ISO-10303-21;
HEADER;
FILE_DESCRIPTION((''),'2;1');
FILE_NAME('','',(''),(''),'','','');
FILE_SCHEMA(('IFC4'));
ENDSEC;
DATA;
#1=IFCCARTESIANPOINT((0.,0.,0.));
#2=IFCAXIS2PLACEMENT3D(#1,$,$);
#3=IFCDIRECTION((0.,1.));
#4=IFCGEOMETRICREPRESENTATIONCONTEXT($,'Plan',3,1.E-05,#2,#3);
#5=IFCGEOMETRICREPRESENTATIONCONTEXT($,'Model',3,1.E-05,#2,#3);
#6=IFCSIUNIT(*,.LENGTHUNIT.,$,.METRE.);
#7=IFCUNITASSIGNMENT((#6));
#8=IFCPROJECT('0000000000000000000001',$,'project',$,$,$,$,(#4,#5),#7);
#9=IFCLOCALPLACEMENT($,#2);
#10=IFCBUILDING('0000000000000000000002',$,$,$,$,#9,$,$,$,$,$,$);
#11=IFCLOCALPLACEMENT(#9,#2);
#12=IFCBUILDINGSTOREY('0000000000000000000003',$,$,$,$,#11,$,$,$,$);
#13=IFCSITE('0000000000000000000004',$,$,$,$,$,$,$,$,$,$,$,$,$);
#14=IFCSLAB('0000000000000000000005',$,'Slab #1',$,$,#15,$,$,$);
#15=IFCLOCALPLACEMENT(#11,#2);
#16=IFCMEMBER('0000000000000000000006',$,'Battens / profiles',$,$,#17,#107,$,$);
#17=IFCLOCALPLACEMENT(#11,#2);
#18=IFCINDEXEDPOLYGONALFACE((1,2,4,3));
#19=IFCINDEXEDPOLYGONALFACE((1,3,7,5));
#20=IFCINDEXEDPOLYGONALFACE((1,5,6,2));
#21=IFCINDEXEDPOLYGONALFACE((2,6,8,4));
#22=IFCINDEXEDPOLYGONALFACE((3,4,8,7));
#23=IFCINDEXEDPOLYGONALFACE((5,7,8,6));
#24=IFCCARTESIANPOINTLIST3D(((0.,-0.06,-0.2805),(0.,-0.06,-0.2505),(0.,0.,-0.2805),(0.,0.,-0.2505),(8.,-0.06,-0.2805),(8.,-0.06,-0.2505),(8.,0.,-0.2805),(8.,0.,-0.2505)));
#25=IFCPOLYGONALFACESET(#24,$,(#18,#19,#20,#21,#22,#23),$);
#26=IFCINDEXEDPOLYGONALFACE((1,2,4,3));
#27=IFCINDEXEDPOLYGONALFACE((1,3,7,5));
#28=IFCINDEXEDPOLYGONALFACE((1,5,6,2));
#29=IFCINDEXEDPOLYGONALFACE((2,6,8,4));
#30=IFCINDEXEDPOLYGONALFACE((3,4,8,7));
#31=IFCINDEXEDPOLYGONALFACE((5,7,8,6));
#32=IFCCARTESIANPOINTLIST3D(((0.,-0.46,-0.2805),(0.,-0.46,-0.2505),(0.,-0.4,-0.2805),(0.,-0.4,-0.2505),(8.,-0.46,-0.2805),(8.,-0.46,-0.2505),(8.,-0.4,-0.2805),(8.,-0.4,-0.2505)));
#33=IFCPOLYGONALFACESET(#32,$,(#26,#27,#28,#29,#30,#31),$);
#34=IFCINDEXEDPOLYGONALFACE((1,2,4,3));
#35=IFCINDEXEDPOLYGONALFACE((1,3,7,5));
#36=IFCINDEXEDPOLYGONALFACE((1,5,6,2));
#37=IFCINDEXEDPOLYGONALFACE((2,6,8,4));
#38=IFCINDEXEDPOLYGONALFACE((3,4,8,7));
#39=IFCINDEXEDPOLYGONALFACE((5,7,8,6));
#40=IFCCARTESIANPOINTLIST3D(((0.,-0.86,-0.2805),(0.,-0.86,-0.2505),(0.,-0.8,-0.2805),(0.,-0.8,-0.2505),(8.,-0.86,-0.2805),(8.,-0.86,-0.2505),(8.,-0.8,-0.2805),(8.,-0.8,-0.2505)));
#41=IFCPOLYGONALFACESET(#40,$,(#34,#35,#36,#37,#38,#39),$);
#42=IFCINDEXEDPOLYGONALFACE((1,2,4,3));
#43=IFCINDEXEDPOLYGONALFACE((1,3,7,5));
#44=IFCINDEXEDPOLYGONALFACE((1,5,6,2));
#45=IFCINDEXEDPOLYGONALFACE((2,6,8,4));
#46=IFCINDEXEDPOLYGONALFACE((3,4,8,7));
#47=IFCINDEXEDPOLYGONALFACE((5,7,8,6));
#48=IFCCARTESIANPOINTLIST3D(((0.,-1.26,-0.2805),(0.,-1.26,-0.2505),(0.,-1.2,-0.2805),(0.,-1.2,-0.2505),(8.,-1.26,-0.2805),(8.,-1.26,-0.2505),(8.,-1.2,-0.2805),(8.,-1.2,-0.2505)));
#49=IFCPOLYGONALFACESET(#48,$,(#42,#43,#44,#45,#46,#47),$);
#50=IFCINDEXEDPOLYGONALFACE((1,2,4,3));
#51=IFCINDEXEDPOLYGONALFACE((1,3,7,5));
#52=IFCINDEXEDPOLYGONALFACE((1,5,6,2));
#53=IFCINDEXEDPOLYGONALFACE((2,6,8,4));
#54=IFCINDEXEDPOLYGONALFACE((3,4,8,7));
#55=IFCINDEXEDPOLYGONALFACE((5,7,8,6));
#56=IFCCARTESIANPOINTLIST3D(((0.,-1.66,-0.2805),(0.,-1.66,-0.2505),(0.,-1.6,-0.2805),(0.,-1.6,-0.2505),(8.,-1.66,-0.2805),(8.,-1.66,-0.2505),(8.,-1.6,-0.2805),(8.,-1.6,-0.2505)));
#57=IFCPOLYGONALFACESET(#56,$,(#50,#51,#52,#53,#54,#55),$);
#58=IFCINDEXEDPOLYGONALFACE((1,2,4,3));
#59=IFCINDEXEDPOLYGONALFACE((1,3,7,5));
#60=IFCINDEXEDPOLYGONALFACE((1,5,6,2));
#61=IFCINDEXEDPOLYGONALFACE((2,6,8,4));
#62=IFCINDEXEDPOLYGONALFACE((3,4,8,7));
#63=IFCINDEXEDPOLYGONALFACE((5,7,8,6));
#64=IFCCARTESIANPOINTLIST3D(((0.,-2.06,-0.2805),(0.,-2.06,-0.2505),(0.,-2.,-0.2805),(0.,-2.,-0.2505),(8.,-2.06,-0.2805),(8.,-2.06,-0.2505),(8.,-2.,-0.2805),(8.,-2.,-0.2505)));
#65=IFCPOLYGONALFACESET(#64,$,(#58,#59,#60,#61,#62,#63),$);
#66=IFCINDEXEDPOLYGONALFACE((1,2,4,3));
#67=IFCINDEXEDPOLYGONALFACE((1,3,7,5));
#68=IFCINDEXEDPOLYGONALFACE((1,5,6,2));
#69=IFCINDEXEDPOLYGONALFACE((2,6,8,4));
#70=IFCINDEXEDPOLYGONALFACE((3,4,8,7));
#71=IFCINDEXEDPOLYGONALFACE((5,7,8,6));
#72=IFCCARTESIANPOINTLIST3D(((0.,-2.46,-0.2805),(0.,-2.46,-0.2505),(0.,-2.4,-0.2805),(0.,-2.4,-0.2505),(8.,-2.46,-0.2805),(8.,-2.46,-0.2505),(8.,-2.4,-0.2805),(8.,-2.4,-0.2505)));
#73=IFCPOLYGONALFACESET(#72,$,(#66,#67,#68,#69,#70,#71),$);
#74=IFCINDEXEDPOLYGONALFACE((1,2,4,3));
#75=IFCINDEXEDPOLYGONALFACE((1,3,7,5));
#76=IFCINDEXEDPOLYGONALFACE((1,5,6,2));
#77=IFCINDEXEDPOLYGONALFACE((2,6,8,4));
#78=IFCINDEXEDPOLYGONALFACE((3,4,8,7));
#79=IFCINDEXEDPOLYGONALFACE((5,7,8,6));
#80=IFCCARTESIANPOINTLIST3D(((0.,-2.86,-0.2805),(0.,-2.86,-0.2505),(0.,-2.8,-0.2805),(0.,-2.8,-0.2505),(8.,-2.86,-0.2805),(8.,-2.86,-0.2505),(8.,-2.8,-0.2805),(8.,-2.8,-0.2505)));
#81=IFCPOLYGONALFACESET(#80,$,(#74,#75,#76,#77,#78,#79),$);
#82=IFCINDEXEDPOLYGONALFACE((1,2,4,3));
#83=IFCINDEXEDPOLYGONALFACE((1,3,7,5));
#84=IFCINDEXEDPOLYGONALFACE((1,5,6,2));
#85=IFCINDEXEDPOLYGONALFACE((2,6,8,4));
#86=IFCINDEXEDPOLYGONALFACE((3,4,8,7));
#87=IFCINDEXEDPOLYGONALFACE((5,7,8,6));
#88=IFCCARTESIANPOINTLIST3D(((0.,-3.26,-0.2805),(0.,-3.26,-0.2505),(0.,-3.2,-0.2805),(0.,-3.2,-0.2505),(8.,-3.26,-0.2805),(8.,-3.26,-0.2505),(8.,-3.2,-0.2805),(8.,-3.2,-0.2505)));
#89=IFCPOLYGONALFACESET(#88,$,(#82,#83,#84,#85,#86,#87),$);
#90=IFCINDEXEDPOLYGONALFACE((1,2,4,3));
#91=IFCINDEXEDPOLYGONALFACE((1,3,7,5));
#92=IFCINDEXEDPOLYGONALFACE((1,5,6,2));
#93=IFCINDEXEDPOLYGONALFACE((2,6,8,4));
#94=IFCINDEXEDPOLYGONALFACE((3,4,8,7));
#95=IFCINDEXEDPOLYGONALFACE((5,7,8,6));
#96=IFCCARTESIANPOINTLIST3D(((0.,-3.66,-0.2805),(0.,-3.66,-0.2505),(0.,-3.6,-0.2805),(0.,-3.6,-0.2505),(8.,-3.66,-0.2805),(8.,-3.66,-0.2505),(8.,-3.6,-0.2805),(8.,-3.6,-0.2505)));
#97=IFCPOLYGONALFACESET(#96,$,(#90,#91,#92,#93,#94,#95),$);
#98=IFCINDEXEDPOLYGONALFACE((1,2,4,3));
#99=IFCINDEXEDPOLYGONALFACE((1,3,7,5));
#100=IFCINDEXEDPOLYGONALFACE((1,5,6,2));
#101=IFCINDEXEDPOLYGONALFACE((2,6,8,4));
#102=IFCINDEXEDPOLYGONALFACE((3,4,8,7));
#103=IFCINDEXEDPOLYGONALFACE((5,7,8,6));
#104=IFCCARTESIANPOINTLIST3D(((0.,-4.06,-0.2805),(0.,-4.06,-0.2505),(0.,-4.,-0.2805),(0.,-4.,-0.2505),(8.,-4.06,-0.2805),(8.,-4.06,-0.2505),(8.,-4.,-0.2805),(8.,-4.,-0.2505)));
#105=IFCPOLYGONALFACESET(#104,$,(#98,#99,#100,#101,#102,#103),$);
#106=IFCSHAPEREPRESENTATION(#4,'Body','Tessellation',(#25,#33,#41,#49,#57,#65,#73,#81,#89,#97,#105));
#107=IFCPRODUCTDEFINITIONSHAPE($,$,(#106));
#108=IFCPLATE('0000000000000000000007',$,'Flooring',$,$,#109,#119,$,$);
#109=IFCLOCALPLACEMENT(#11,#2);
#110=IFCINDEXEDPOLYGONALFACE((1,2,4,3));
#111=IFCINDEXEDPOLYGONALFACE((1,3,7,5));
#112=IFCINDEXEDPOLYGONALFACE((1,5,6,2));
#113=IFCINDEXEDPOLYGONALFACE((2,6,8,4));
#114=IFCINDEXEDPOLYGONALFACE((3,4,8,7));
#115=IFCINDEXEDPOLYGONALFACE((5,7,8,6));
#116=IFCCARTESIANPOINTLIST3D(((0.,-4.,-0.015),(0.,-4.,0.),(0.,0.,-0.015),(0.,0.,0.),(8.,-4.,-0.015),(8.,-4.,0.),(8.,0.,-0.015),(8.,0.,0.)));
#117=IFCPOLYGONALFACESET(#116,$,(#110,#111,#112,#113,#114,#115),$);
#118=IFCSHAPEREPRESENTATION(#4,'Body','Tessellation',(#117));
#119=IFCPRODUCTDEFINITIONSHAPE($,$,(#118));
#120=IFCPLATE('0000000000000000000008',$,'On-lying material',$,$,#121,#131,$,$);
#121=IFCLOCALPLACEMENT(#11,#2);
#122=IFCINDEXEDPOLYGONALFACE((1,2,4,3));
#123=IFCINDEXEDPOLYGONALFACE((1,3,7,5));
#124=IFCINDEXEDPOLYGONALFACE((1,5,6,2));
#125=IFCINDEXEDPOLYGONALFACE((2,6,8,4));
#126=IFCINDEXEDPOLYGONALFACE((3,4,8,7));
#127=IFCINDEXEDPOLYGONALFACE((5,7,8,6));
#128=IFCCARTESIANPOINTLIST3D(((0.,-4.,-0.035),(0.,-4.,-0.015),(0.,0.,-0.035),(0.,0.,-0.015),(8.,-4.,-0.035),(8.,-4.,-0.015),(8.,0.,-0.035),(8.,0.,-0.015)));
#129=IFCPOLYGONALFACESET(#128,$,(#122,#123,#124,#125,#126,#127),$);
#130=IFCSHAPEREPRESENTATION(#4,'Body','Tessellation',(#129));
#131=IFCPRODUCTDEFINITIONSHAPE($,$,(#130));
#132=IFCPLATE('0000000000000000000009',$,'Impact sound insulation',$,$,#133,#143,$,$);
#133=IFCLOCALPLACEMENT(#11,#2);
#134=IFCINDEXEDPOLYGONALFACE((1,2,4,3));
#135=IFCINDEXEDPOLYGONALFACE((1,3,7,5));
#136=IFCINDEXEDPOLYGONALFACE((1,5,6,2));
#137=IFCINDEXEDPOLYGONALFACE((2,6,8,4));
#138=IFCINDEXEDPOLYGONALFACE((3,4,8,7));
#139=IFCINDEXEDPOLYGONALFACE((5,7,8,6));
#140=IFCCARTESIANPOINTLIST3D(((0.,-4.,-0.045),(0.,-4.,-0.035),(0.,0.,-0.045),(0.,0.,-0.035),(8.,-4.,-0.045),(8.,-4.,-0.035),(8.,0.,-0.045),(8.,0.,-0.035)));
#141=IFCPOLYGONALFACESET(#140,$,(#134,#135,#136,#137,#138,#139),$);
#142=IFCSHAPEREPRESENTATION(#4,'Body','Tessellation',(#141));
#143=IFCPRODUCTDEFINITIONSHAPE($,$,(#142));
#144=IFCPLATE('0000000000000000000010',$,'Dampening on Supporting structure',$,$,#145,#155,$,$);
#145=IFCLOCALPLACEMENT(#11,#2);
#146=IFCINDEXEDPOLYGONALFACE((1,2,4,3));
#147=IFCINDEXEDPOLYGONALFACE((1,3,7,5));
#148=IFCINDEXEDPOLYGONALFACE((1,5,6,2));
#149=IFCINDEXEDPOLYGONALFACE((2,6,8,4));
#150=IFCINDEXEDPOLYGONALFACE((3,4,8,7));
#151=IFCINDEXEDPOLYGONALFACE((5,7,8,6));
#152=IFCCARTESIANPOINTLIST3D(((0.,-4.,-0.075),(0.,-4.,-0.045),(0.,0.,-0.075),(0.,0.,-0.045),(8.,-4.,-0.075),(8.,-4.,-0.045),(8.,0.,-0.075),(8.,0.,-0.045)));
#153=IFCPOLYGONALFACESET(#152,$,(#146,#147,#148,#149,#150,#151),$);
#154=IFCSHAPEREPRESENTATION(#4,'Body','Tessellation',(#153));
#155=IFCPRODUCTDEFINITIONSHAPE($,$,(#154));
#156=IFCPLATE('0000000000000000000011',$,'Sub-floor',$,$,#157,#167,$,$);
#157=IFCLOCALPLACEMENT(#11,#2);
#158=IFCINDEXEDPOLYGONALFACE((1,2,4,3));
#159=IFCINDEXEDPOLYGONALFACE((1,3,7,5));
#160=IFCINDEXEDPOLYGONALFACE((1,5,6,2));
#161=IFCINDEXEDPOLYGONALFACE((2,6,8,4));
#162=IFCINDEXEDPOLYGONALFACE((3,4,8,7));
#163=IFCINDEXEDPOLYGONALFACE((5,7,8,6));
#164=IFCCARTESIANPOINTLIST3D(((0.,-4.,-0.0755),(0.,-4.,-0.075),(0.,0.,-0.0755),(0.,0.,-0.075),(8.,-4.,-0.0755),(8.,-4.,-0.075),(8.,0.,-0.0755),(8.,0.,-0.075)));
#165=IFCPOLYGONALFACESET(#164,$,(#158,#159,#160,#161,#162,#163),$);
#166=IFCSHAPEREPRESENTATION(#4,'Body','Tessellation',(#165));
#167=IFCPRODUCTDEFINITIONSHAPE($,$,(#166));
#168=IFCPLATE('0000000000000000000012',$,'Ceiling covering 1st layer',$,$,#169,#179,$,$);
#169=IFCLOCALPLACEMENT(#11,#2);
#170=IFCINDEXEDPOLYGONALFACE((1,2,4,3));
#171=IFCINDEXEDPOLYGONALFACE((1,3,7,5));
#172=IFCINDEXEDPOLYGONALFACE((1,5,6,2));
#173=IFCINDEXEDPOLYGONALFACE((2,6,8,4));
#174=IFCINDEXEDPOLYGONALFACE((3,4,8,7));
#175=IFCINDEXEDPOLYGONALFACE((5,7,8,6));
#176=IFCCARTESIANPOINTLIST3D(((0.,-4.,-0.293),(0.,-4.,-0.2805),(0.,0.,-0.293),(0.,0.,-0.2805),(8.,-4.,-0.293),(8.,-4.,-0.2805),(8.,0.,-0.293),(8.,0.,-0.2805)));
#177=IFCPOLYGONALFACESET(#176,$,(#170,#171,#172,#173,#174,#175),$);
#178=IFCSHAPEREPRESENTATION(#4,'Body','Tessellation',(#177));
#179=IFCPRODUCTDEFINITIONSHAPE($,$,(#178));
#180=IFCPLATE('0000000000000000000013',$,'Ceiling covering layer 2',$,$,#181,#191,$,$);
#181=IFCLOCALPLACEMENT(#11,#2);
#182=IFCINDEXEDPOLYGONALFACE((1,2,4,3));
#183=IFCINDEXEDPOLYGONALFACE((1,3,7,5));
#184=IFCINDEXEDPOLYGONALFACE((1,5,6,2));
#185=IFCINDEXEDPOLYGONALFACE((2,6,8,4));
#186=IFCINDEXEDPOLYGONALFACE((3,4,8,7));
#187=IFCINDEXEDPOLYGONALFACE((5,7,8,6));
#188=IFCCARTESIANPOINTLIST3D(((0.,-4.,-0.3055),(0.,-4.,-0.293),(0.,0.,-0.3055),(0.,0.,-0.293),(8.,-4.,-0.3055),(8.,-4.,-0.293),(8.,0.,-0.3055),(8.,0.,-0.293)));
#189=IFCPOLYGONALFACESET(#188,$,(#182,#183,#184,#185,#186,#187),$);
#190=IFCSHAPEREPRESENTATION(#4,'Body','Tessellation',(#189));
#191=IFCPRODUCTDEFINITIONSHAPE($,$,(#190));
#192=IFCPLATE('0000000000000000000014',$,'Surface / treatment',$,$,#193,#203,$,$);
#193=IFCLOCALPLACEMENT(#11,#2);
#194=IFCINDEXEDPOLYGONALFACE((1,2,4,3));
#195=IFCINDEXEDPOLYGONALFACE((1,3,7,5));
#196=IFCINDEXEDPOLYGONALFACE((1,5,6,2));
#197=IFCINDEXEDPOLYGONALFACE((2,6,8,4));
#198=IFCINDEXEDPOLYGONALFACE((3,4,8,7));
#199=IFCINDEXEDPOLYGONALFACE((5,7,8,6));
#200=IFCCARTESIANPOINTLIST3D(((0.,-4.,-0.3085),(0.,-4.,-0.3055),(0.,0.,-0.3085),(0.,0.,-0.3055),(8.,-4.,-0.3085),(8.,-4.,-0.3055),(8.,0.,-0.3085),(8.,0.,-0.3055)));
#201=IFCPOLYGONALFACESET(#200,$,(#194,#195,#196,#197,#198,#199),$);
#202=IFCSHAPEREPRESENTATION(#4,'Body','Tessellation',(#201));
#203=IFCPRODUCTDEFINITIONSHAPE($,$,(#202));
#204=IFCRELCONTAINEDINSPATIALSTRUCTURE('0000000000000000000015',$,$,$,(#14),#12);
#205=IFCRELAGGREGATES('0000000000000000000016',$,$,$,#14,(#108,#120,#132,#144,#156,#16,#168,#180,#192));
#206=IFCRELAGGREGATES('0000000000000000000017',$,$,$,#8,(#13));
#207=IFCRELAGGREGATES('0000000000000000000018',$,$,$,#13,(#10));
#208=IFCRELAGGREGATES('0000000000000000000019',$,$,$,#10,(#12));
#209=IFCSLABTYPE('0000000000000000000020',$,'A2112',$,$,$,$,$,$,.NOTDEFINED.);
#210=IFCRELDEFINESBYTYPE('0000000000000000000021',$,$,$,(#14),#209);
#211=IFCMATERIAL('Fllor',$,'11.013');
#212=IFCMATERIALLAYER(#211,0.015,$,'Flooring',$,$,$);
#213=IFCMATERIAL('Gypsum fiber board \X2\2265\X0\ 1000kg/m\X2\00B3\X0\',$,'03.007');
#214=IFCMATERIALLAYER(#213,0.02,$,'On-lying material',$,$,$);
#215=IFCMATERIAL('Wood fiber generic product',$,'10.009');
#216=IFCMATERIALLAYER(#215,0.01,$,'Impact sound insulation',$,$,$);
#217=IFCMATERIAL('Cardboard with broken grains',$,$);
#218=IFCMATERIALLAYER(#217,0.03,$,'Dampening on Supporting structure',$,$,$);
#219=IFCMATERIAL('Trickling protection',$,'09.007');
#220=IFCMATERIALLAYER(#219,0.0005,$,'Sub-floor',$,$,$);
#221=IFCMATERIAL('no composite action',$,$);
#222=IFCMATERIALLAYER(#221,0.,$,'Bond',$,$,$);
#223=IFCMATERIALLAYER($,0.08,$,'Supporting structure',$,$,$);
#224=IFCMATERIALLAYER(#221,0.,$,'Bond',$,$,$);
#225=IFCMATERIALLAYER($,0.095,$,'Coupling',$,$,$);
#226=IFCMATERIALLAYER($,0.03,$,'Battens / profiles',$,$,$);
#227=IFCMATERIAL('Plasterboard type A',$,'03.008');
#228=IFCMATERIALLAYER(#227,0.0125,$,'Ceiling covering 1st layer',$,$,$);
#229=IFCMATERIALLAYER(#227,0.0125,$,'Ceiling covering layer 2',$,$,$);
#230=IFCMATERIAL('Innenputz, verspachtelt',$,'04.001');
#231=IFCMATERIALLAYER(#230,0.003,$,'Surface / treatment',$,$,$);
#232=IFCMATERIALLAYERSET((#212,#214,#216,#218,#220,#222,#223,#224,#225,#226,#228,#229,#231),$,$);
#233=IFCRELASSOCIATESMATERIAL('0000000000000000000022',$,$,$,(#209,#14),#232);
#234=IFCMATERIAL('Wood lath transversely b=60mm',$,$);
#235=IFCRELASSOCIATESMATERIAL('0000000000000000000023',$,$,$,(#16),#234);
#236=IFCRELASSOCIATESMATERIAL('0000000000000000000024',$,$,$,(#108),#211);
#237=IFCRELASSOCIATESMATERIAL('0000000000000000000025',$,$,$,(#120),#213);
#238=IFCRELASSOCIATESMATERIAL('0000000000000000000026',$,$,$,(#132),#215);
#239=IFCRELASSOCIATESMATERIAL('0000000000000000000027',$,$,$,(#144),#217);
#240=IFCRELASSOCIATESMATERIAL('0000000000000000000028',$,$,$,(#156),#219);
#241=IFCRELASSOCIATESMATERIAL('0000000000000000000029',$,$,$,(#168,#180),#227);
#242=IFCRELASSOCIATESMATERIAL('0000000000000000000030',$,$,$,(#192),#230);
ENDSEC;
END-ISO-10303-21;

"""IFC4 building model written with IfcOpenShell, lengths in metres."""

from ifc_helpers import new_model, si_unit, direction, frame, frame_2d, origin, origin_with_axes, place, context, project, spatial, rectangle, extrude, material, layer, layer_set, type_object, element, aggregate, save


model = new_model("IFC4")

# Units and contexts
plan_context = context("Plan", 3, precision=1e-05, world=origin(), true_north=direction((0.0, 1.0)))
model_context = context("Model", 3, precision=1e-05, world=origin(), true_north=direction((0.0, 1.0)))
ifc_project = project(units=[si_unit("LENGTHUNIT", "METRE")], contexts=[plan_context, model_context])

# Site, building, storey
site = spatial("IfcSite", under=ifc_project)
building_placement = place(None, origin())
building = spatial("IfcBuilding", under=site, at=building_placement)
storey_placement = place(building_placement, origin())
storey = spatial("IfcBuildingStorey", under=building, at=storey_placement)

# Slab, member, plates
ifc_material_1 = material(Name="Fllor", Category="11.013")
ifc_layer_1 = layer(ifc_material_1, 0.015, Name="Flooring")
ifc_material_2 = material(Name="Gypsum fiber board ≥ 1000kg/m³", Category="03.007")
ifc_layer_2 = layer(ifc_material_2, 0.02, Name="On-lying material")
ifc_material_3 = material(Name="Wood fiber generic product", Category="10.009")
ifc_layer_3 = layer(ifc_material_3, 0.01, Name="Impact sound insulation")
ifc_material_4 = material(Name="Cardboard with broken grains")
ifc_layer_4 = layer(ifc_material_4, 0.03, Name="Dampening on Supporting structure")
ifc_material_5 = material(Name="Trickling protection", Category="09.007")
ifc_layer_5 = layer(ifc_material_5, 0.0005, Name="Sub-floor")
ifc_material_6 = material(Name="no composite action")
ifc_layer_6 = layer(ifc_material_6, 0.0, Name="Bond")
ifc_layer_7 = layer(None, 0.08, Name="Supporting structure")
ifc_layer_8 = layer(ifc_material_6, 0.0, Name="Bond")
ifc_layer_9 = layer(None, 0.095, Name="Coupling")
ifc_layer_10 = layer(None, 0.03, Name="Battens / profiles")
ifc_material_7 = material(Name="Plasterboard type A", Category="03.008")
ifc_layer_11 = layer(ifc_material_7, 0.0125, Name="Ceiling covering 1st layer")
ifc_layer_12 = layer(ifc_material_7, 0.0125, Name="Ceiling covering layer 2")
ifc_material_8 = material(Name="Innenputz, verspachtelt", Category="04.001")
ifc_layer_13 = layer(ifc_material_8, 0.003, Name="Surface / treatment")
ifc_layer_set = layer_set([ifc_layer_1, ifc_layer_2, ifc_layer_3, ifc_layer_4, ifc_layer_5, ifc_layer_6, ifc_layer_7, ifc_layer_8, ifc_layer_9, ifc_layer_10, ifc_layer_11, ifc_layer_12, ifc_layer_13])
slab_type = type_object("IfcSlabType", Name="A2112", PredefinedType="NOTDEFINED", material=ifc_layer_set)
slab_placement = place(None, frame((0.0, 0.0, 0.0), z_axis=(0.0, 0.0, -1.0), x_axis=(1.0, 0.0, 0.0)))
slab = element("IfcSlab", 1, at=slab_placement, inside=storey, type_object=slab_type, material=ifc_layer_set, Name="Slab #1")
ifc_material_9 = material(Name="Wood lath transversely b=60mm")
member_1_placement = place(slab_placement, origin())
member_1 = element("IfcMember", 2, at=member_1_placement, material=ifc_material_9, Name="Battens / profiles", context=plan_context, shape_type="SweptSolid", body=[
    extrude(rectangle(XDim=0.06, YDim=0.03, at=frame_2d((0.03, 0.015), x_axis=(1.0, 0.0))), frame((0.0, 0.0, 0.2505), z_axis=(1.0, 0.0, 0.0), x_axis=(0.0, 1.0, 0.0)), (0.0, 0.0, 1.0), 8.0),
    extrude(rectangle(XDim=0.06, YDim=0.03, at=frame_2d((0.03, 0.015), x_axis=(1.0, 0.0))), frame((0.0, 0.4, 0.2505), z_axis=(1.0, 0.0, 0.0), x_axis=(0.0, 1.0, 0.0)), (0.0, 0.0, 1.0), 8.0),
    extrude(rectangle(XDim=0.06, YDim=0.03, at=frame_2d((0.03, 0.015), x_axis=(1.0, 0.0))), frame((0.0, 0.8, 0.2505), z_axis=(1.0, 0.0, 0.0), x_axis=(0.0, 1.0, 0.0)), (0.0, 0.0, 1.0), 8.0),
    extrude(rectangle(XDim=0.06, YDim=0.03, at=frame_2d((0.03, 0.015), x_axis=(1.0, 0.0))), frame((0.0, 1.2, 0.2505), z_axis=(1.0, 0.0, 0.0), x_axis=(0.0, 1.0, 0.0)), (0.0, 0.0, 1.0), 8.0),
    extrude(rectangle(XDim=0.06, YDim=0.03, at=frame_2d((0.03, 0.015), x_axis=(1.0, 0.0))), frame((0.0, 1.6, 0.2505), z_axis=(1.0, 0.0, 0.0), x_axis=(0.0, 1.0, 0.0)), (0.0, 0.0, 1.0), 8.0),
    extrude(rectangle(XDim=0.06, YDim=0.03, at=frame_2d((0.03, 0.015), x_axis=(1.0, 0.0))), frame((0.0, 2.0, 0.2505), z_axis=(1.0, 0.0, 0.0), x_axis=(0.0, 1.0, 0.0)), (0.0, 0.0, 1.0), 8.0),
    extrude(rectangle(XDim=0.06, YDim=0.03, at=frame_2d((0.03, 0.015), x_axis=(1.0, 0.0))), frame((0.0, 2.4, 0.2505), z_axis=(1.0, 0.0, 0.0), x_axis=(0.0, 1.0, 0.0)), (0.0, 0.0, 1.0), 8.0),
    extrude(rectangle(XDim=0.06, YDim=0.03, at=frame_2d((0.03, 0.015), x_axis=(1.0, 0.0))), frame((0.0, 2.8, 0.2505), z_axis=(1.0, 0.0, 0.0), x_axis=(0.0, 1.0, 0.0)), (0.0, 0.0, 1.0), 8.0),
    extrude(rectangle(XDim=0.06, YDim=0.03, at=frame_2d((0.03, 0.015), x_axis=(1.0, 0.0))), frame((0.0, 3.2, 0.2505), z_axis=(1.0, 0.0, 0.0), x_axis=(0.0, 1.0, 0.0)), (0.0, 0.0, 1.0), 8.0),
    extrude(rectangle(XDim=0.06, YDim=0.03, at=frame_2d((0.03, 0.015), x_axis=(1.0, 0.0))), frame((0.0, 3.6, 0.2505), z_axis=(1.0, 0.0, 0.0), x_axis=(0.0, 1.0, 0.0)), (0.0, 0.0, 1.0), 8.0),
    extrude(rectangle(XDim=0.06, YDim=0.03, at=frame_2d((0.03, 0.015), x_axis=(1.0, 0.0))), frame((0.0, 4.0, 0.2505), z_axis=(1.0, 0.0, 0.0), x_axis=(0.0, 1.0, 0.0)), (0.0, 0.0, 1.0), 8.0),
])
plate_1_placement = place(slab_placement, origin())
plate_1 = element("IfcPlate", 3, at=plate_1_placement, material=ifc_material_1, Name="Flooring", context=plan_context, shape_type="SweptSolid", body=[
    extrude(rectangle(XDim=8.0, YDim=4.0, at=frame_2d((4.0, 2.0), x_axis=(1.0, 0.0))), origin_with_axes(), (0.0, 0.0, 1.0), 0.015),
])
plate_2_placement = place(slab_placement, origin())
plate_2 = element("IfcPlate", 4, at=plate_2_placement, material=ifc_material_2, Name="On-lying material", context=plan_context, shape_type="SweptSolid", body=[
    extrude(rectangle(XDim=8.0, YDim=4.0, at=frame_2d((4.0, 2.0), x_axis=(1.0, 0.0))), frame((0.0, 0.0, 0.015), z_axis=(0.0, 0.0, 1.0), x_axis=(1.0, 0.0, 0.0)), (0.0, 0.0, 1.0), 0.02),
])
plate_3_placement = place(slab_placement, origin())
plate_3 = element("IfcPlate", 5, at=plate_3_placement, material=ifc_material_3, Name="Impact sound insulation", context=plan_context, shape_type="SweptSolid", body=[
    extrude(rectangle(XDim=8.0, YDim=4.0, at=frame_2d((4.0, 2.0), x_axis=(1.0, 0.0))), frame((0.0, 0.0, 0.035), z_axis=(0.0, 0.0, 1.0), x_axis=(1.0, 0.0, 0.0)), (0.0, 0.0, 1.0), 0.01),
])
plate_4_placement = place(slab_placement, origin())
plate_4 = element("IfcPlate", 6, at=plate_4_placement, material=ifc_material_4, Name="Dampening on Supporting structure", context=plan_context, shape_type="SweptSolid", body=[
    extrude(rectangle(XDim=8.0, YDim=4.0, at=frame_2d((4.0, 2.0), x_axis=(1.0, 0.0))), frame((0.0, 0.0, 0.045), z_axis=(0.0, 0.0, 1.0), x_axis=(1.0, 0.0, 0.0)), (0.0, 0.0, 1.0), 0.03),
])
plate_5_placement = place(slab_placement, origin())
plate_5 = element("IfcPlate", 7, at=plate_5_placement, material=ifc_material_5, Name="Sub-floor", context=plan_context, shape_type="SweptSolid", body=[
    extrude(rectangle(XDim=8.0, YDim=4.0, at=frame_2d((4.0, 2.0), x_axis=(1.0, 0.0))), frame((0.0, 0.0, 0.075), z_axis=(0.0, 0.0, 1.0), x_axis=(1.0, 0.0, 0.0)), (0.0, 0.0, 1.0), 0.0005),
])
plate_6_placement = place(slab_placement, origin())
plate_6 = element("IfcPlate", 8, at=plate_6_placement, material=ifc_material_7, Name="Ceiling covering 1st layer", context=plan_context, shape_type="SweptSolid", body=[
    extrude(rectangle(XDim=8.0, YDim=4.0, at=frame_2d((4.0, 2.0), x_axis=(1.0, 0.0))), frame((0.0, 0.0, 0.2805), z_axis=(0.0, 0.0, 1.0), x_axis=(1.0, 0.0, 0.0)), (0.0, 0.0, 1.0), 0.0125),
])
plate_7_placement = place(slab_placement, origin())
plate_7 = element("IfcPlate", 9, at=plate_7_placement, material=ifc_material_7, Name="Ceiling covering layer 2", context=plan_context, shape_type="SweptSolid", body=[
    extrude(rectangle(XDim=8.0, YDim=4.0, at=frame_2d((4.0, 2.0), x_axis=(1.0, 0.0))), frame((0.0, 0.0, 0.293), z_axis=(0.0, 0.0, 1.0), x_axis=(1.0, 0.0, 0.0)), (0.0, 0.0, 1.0), 0.0125),
])
plate_8_placement = place(slab_placement, origin())
plate_8 = element("IfcPlate", 10, at=plate_8_placement, material=ifc_material_8, Name="Surface / treatment", context=plan_context, shape_type="SweptSolid", body=[
    extrude(rectangle(XDim=8.0, YDim=4.0, at=frame_2d((4.0, 2.0), x_axis=(1.0, 0.0))), frame((0.0, 0.0, 0.3055), z_axis=(0.0, 0.0, 1.0), x_axis=(1.0, 0.0, 0.0)), (0.0, 0.0, 1.0), 0.003),
])
aggregate(slab, [plate_1, plate_2, plate_3, plate_4, plate_5, member_1, plate_6, plate_7, plate_8])

save(model, "model.ifc")
